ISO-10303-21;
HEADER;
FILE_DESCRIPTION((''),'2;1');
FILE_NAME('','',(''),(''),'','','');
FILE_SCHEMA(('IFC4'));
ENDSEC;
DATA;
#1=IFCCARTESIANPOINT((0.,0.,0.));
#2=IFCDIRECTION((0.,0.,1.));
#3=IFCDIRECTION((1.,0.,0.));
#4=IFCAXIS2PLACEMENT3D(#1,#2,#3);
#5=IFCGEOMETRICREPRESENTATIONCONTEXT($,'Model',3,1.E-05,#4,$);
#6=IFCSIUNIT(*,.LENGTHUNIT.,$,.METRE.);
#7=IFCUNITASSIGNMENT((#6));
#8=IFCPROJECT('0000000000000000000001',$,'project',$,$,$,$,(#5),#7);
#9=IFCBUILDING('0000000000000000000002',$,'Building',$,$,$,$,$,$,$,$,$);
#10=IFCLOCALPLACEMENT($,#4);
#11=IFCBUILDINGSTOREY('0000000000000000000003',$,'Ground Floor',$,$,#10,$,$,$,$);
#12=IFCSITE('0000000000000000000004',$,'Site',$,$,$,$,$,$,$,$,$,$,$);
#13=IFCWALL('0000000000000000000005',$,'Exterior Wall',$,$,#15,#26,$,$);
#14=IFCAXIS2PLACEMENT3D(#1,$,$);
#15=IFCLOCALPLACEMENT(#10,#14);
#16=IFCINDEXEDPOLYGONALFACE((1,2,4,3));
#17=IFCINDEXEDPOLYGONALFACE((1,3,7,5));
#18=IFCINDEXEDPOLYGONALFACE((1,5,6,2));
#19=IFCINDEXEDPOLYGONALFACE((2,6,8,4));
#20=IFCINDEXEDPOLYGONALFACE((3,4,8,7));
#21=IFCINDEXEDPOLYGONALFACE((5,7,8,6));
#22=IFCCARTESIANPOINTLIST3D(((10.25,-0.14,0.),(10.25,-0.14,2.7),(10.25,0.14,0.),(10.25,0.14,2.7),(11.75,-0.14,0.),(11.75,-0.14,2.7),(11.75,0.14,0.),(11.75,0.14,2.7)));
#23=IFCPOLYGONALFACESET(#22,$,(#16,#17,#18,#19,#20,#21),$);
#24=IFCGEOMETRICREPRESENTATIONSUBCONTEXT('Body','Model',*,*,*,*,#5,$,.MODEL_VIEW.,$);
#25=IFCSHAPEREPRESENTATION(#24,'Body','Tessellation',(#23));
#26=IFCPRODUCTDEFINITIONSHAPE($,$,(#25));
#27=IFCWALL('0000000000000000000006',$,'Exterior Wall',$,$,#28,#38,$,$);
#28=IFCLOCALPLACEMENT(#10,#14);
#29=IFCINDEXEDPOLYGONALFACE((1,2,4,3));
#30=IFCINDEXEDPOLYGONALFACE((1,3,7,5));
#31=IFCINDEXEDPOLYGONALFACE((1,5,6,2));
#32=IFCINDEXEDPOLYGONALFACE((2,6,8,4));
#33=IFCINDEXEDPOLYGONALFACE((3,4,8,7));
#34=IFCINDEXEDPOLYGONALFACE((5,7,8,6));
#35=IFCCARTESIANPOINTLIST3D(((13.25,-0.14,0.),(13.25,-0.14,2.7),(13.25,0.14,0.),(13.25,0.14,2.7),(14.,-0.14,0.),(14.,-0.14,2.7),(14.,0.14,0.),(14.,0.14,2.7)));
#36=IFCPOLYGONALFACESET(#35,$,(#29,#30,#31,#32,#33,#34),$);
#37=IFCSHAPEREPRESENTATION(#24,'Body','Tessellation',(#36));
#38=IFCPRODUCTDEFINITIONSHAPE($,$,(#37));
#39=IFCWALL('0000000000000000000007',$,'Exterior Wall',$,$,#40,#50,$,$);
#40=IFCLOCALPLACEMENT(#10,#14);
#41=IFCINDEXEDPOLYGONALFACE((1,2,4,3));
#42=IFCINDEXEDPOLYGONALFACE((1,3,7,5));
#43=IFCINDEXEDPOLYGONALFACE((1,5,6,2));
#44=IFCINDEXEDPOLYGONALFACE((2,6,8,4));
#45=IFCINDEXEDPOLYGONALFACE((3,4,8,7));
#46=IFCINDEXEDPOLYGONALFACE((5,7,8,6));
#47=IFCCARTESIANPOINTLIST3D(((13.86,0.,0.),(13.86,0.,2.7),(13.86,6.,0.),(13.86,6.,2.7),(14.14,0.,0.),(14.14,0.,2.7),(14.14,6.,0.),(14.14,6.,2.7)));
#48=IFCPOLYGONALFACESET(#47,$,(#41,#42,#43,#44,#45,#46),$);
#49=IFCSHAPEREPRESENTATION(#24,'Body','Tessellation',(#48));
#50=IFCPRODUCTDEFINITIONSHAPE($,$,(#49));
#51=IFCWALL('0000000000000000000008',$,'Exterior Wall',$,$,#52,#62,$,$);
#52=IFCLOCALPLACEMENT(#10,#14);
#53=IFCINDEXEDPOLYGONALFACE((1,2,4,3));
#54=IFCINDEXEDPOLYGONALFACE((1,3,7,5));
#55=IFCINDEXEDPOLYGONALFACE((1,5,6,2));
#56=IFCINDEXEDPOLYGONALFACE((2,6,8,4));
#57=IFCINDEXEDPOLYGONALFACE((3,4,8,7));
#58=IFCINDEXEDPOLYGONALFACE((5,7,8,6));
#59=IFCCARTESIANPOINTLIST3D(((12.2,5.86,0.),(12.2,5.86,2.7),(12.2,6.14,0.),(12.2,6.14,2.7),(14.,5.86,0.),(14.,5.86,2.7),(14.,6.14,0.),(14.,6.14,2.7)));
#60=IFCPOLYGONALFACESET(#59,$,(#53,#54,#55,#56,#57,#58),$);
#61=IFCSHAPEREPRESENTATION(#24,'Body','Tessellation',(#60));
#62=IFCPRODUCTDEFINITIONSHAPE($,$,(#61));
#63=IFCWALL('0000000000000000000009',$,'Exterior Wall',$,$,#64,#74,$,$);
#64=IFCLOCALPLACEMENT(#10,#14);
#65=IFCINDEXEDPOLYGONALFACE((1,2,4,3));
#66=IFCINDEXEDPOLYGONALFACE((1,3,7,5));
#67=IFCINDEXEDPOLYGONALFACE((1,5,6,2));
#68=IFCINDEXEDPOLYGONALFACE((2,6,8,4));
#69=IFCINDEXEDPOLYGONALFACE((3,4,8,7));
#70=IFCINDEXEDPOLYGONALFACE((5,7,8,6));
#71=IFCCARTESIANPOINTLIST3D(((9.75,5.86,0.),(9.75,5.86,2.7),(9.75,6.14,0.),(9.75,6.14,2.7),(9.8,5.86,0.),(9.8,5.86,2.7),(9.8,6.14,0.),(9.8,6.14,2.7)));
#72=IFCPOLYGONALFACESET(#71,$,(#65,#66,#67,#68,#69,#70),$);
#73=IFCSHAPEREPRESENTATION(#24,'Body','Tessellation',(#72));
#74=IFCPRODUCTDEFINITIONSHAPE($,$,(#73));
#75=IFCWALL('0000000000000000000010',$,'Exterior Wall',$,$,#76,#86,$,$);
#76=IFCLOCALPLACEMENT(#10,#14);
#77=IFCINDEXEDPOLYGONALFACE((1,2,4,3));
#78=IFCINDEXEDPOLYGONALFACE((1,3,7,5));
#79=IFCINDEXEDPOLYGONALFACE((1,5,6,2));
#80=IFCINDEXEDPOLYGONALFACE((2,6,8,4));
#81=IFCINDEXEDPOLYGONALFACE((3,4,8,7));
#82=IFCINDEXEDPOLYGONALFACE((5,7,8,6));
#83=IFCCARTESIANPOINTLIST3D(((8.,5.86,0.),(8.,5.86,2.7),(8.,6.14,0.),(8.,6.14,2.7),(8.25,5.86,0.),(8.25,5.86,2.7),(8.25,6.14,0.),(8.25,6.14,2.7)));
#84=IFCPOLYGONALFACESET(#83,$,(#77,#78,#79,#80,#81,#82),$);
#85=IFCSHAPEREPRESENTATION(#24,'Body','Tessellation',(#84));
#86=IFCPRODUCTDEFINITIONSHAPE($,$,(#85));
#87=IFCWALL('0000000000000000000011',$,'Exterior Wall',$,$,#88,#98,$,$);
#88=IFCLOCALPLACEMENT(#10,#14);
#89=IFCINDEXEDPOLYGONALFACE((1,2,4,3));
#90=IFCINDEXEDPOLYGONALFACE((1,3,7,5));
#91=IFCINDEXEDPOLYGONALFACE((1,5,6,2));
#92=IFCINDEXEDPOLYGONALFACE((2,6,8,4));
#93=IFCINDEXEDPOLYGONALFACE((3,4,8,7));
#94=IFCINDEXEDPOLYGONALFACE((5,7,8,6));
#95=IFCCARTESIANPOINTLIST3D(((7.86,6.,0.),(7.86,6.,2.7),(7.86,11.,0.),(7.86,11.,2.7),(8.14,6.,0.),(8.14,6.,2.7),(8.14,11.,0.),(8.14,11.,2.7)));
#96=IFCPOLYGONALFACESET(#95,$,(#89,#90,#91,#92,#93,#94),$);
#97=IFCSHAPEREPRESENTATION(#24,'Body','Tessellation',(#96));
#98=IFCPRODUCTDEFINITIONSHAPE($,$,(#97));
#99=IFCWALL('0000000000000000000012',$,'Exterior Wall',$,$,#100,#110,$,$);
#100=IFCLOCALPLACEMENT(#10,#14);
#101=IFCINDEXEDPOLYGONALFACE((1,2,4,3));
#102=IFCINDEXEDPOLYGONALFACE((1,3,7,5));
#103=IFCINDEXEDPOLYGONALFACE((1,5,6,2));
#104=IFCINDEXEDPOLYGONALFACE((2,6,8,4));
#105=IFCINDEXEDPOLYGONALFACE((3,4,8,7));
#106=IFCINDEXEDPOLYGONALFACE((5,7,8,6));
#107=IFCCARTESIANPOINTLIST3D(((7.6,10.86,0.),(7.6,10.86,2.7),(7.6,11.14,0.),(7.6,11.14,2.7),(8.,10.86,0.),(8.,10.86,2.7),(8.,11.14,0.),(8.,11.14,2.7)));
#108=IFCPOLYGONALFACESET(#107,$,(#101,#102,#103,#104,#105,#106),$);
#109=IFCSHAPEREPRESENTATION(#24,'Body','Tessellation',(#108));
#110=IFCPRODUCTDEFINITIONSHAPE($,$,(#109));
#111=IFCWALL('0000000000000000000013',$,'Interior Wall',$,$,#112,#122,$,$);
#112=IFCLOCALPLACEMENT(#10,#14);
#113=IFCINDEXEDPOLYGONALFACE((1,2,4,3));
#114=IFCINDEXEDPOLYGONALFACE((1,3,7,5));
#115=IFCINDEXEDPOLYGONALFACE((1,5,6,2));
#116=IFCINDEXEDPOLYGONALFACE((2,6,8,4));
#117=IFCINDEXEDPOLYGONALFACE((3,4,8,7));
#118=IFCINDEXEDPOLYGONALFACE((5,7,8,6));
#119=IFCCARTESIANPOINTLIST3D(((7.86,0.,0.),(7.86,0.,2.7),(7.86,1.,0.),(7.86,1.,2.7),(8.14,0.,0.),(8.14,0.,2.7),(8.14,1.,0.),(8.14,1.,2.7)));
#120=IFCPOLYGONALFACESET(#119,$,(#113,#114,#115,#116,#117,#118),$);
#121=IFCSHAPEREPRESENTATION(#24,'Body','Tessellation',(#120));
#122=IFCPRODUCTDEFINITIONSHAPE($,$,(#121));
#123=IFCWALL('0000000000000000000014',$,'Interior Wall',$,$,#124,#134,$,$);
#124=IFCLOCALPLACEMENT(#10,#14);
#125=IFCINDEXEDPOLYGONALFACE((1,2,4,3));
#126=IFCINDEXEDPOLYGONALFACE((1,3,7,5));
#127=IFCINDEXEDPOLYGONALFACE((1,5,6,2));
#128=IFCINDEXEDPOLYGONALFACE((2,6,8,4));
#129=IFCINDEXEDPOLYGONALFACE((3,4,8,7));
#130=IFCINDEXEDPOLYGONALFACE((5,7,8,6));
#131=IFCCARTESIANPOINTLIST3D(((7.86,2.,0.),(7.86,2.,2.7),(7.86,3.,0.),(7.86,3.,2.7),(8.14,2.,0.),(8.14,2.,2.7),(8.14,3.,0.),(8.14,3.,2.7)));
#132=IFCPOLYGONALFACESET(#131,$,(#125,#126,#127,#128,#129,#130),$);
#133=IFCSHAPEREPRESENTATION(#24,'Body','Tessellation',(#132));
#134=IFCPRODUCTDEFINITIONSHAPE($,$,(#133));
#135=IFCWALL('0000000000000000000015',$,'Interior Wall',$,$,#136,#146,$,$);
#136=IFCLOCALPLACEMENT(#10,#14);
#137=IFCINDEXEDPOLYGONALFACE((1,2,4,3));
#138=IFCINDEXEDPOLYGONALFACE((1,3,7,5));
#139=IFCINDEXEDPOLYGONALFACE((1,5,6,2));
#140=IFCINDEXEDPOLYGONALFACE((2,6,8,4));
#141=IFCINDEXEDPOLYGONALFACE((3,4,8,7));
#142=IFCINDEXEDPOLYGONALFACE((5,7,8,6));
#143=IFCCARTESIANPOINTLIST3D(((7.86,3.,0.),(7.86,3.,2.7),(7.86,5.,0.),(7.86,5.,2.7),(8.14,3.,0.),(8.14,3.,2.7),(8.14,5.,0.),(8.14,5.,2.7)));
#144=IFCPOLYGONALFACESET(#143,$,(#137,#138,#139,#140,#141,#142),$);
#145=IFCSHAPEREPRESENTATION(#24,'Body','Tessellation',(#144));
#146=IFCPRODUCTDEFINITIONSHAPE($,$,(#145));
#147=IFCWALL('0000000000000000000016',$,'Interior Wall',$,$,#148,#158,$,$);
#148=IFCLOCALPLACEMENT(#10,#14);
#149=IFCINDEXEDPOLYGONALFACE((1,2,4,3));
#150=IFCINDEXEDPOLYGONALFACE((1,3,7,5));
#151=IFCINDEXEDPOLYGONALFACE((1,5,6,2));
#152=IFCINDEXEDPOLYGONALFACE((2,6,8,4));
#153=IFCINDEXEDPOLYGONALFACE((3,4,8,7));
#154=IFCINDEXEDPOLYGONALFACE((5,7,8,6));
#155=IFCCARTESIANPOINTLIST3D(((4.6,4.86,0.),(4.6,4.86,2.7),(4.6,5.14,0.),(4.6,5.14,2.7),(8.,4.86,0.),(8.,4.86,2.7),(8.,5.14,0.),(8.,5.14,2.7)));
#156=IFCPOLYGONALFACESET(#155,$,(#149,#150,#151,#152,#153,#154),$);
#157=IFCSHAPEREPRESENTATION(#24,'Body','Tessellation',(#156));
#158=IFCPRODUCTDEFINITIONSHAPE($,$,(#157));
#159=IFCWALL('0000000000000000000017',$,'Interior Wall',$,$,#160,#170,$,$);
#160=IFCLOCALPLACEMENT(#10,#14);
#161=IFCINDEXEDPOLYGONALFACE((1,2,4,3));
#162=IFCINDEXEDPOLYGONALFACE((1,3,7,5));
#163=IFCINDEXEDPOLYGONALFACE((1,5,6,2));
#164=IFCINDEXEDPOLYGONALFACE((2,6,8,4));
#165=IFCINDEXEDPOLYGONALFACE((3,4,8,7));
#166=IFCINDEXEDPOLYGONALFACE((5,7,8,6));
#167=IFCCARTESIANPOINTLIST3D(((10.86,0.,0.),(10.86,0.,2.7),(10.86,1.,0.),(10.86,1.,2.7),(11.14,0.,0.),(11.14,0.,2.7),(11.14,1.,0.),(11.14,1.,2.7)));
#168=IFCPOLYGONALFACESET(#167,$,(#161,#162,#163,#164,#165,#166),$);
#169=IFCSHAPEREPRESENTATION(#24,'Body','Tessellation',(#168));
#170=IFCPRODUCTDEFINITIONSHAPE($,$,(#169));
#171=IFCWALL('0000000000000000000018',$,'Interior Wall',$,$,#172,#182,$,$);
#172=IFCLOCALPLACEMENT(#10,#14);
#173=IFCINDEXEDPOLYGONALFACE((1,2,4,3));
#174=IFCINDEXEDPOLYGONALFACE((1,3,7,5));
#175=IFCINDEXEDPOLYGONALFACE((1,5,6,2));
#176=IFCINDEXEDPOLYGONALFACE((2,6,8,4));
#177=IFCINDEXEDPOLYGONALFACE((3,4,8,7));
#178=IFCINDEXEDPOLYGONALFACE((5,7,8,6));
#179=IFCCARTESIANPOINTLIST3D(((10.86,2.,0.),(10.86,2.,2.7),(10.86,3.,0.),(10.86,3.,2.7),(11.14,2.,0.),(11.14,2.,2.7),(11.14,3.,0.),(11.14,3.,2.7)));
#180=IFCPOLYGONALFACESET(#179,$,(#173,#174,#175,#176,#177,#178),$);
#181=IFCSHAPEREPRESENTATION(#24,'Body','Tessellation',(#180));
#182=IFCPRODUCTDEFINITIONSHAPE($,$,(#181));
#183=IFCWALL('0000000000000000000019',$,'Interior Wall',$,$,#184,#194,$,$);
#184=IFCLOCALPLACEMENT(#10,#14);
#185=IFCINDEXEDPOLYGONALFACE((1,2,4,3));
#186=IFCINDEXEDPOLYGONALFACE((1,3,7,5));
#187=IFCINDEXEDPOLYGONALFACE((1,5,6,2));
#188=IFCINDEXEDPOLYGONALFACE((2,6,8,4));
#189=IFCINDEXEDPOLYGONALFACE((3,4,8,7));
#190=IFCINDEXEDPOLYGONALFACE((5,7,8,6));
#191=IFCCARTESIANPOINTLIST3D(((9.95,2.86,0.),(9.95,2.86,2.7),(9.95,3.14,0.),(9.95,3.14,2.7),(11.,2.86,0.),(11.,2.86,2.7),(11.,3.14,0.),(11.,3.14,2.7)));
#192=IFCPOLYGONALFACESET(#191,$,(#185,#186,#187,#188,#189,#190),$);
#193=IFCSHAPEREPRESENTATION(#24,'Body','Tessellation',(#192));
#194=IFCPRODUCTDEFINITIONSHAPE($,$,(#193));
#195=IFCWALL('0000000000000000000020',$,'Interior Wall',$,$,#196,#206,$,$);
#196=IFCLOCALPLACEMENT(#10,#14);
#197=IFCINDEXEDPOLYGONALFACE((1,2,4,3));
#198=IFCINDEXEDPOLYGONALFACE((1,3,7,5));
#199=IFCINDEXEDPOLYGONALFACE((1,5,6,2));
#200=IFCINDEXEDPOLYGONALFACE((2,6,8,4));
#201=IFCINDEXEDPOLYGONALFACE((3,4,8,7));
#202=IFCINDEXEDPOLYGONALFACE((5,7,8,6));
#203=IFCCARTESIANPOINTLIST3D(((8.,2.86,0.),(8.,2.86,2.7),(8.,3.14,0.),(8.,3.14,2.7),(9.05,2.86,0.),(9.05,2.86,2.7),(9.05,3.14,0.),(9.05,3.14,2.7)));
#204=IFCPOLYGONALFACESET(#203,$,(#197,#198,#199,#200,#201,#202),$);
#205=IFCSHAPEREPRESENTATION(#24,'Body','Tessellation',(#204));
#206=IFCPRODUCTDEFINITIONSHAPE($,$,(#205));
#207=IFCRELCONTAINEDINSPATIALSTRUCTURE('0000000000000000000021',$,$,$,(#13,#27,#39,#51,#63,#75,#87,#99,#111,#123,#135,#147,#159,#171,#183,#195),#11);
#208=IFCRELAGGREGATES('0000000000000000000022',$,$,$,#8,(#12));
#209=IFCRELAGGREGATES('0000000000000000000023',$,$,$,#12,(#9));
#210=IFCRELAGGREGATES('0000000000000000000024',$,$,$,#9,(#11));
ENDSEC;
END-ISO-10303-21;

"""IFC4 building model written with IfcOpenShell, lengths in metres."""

from ifc_helpers import new_model, si_unit, frame, origin_with_axes, place, context, subcontext, project, spatial, indexed_curve, outline, extrude, element, save


model = new_model("IFC4")

# Units and contexts
model_context = context("Model", 3, precision=1e-05, world=origin_with_axes())
body_context = subcontext(model_context, "Body", "Model", "MODEL_VIEW")
ifc_project = project(units=[si_unit("LENGTHUNIT", "METRE")], contexts=[model_context])

# Site, building, storey
site = spatial("IfcSite", under=ifc_project, Name="Site")
building = spatial("IfcBuilding", under=site, Name="Building")
storey_placement = place(None, origin_with_axes())
storey = spatial("IfcBuildingStorey", under=building, at=storey_placement, Name="Ground Floor")

# Walls
wall_1_placement = place(storey_placement, frame((10.25, 0.0, 0.0), z_axis=(0.0, 0.0, 1.0), x_axis=(1.0, 0.0, 0.0)))
element("IfcWall", 1, at=wall_1_placement, inside=storey, Name="Exterior Wall", context=body_context, shape_type="SweptSolid", body=[
    extrude(outline(indexed_curve([(0.0, 0.0), (0.0, 0.28), (1.5, 0.28), (1.5, 0.0), (0.0, 0.0)], self_intersect=False)), frame((0.0, -0.14, 0.0), z_axis=(0.0, 0.0, 1.0), x_axis=(1.0, 0.0, 0.0)), (0.0, 0.0, 1.0), 2.7),
])
wall_2_placement = place(storey_placement, frame((13.25, 0.0, 0.0), z_axis=(0.0, 0.0, 1.0), x_axis=(1.0, 0.0, 0.0)))
element("IfcWall", 2, at=wall_2_placement, inside=storey, Name="Exterior Wall", context=body_context, shape_type="SweptSolid", body=[
    extrude(outline(indexed_curve([(0.0, 0.0), (0.0, 0.28), (0.75, 0.28), (0.75, 0.0), (0.0, 0.0)], self_intersect=False)), frame((0.0, -0.14, 0.0), z_axis=(0.0, 0.0, 1.0), x_axis=(1.0, 0.0, 0.0)), (0.0, 0.0, 1.0), 2.7),
])
wall_3_placement = place(storey_placement, frame((14.0, 0.0, 0.0), z_axis=(0.0, 0.0, 1.0), x_axis=(0.0, 1.0, 0.0)))
element("IfcWall", 3, at=wall_3_placement, inside=storey, Name="Exterior Wall", context=body_context, shape_type="SweptSolid", body=[
    extrude(outline(indexed_curve([(0.0, 0.0), (0.0, 0.28), (6.0, 0.28), (6.0, 0.0), (0.0, 0.0)], self_intersect=False)), frame((0.0, -0.14, 0.0), z_axis=(0.0, 0.0, 1.0), x_axis=(1.0, 0.0, 0.0)), (0.0, 0.0, 1.0), 2.7),
])
wall_4_placement = place(storey_placement, frame((14.0, 6.0, 0.0), z_axis=(0.0, 0.0, 1.0), x_axis=(-1.0, 0.0, 0.0)))
element("IfcWall", 4, at=wall_4_placement, inside=storey, Name="Exterior Wall", context=body_context, shape_type="SweptSolid", body=[
    extrude(outline(indexed_curve([(0.0, 0.0), (0.0, 0.28), (1.8, 0.28), (1.8, 0.0), (0.0, 0.0)], self_intersect=False)), frame((0.0, -0.14, 0.0), z_axis=(0.0, 0.0, 1.0), x_axis=(1.0, 0.0, 0.0)), (0.0, 0.0, 1.0), 2.7),
])
wall_5_placement = place(storey_placement, frame((9.8, 6.0, 0.0), z_axis=(0.0, 0.0, 1.0), x_axis=(-1.0, 0.0, 0.0)))
element("IfcWall", 5, at=wall_5_placement, inside=storey, Name="Exterior Wall", context=body_context, shape_type="SweptSolid", body=[
    extrude(outline(indexed_curve([(0.0, 0.0), (0.0, 0.28), (0.05, 0.28), (0.05, 0.0), (0.0, 0.0)], self_intersect=False)), frame((0.0, -0.14, 0.0), z_axis=(0.0, 0.0, 1.0), x_axis=(1.0, 0.0, 0.0)), (0.0, 0.0, 1.0), 2.7),
])
wall_6_placement = place(storey_placement, frame((8.25, 6.0, 0.0), z_axis=(0.0, 0.0, 1.0), x_axis=(-1.0, 0.0, 0.0)))
element("IfcWall", 6, at=wall_6_placement, inside=storey, Name="Exterior Wall", context=body_context, shape_type="SweptSolid", body=[
    extrude(outline(indexed_curve([(0.0, 0.0), (0.0, 0.28), (0.25, 0.28), (0.25, 0.0), (0.0, 0.0)], self_intersect=False)), frame((0.0, -0.14, 0.0), z_axis=(0.0, 0.0, 1.0), x_axis=(1.0, 0.0, 0.0)), (0.0, 0.0, 1.0), 2.7),
])
wall_7_placement = place(storey_placement, frame((8.0, 6.0, 0.0), z_axis=(0.0, 0.0, 1.0), x_axis=(0.0, 1.0, 0.0)))
element("IfcWall", 7, at=wall_7_placement, inside=storey, Name="Exterior Wall", context=body_context, shape_type="SweptSolid", body=[
    extrude(outline(indexed_curve([(0.0, 0.0), (0.0, 0.28), (5.0, 0.28), (5.0, 0.0), (0.0, 0.0)], self_intersect=False)), frame((0.0, -0.14, 0.0), z_axis=(0.0, 0.0, 1.0), x_axis=(1.0, 0.0, 0.0)), (0.0, 0.0, 1.0), 2.7),
])
wall_8_placement = place(storey_placement, frame((8.0, 11.0, 0.0), z_axis=(0.0, 0.0, 1.0), x_axis=(-1.0, 0.0, 0.0)))
element("IfcWall", 8, at=wall_8_placement, inside=storey, Name="Exterior Wall", context=body_context, shape_type="SweptSolid", body=[
    extrude(outline(indexed_curve([(0.0, 0.0), (0.0, 0.28), (0.4, 0.28), (0.4, 0.0), (0.0, 0.0)], self_intersect=False)), frame((0.0, -0.14, 0.0), z_axis=(0.0, 0.0, 1.0), x_axis=(1.0, 0.0, 0.0)), (0.0, 0.0, 1.0), 2.7),
])
for number, where, z_axis, x_axis, name in (
    (9, (8.0, 0.0, 0.0), (0.0, 0.0, 1.0), (0.0, 1.0, 0.0), "Interior Wall"),
    (10, (8.0, 2.0, 0.0), (0.0, 0.0, 1.0), (0.0, 1.0, 0.0), "Interior Wall"),
):
    element("IfcWall", number, at=place(storey_placement, frame(where, z_axis=z_axis, x_axis=x_axis)), inside=storey, Name=name, context=body_context, shape_type="SweptSolid", body=[
        extrude(outline(indexed_curve([(0.0, 0.0), (0.0, 0.28), (1.0, 0.28), (1.0, 0.0), (0.0, 0.0)], self_intersect=False)), frame((0.0, -0.14, 0.0), z_axis=(0.0, 0.0, 1.0), x_axis=(1.0, 0.0, 0.0)), (0.0, 0.0, 1.0), 2.7),
    ])
wall_9_placement = place(storey_placement, frame((8.0, 3.0, 0.0), z_axis=(0.0, 0.0, 1.0), x_axis=(0.0, 1.0, 0.0)))
element("IfcWall", 11, at=wall_9_placement, inside=storey, Name="Interior Wall", context=body_context, shape_type="SweptSolid", body=[
    extrude(outline(indexed_curve([(0.0, 0.0), (0.0, 0.28), (2.0, 0.28), (2.0, 0.0), (0.0, 0.0)], self_intersect=False)), frame((0.0, -0.14, 0.0), z_axis=(0.0, 0.0, 1.0), x_axis=(1.0, 0.0, 0.0)), (0.0, 0.0, 1.0), 2.7),
])
wall_10_placement = place(storey_placement, frame((8.0, 5.0, 0.0), z_axis=(0.0, 0.0, 1.0), x_axis=(-1.0, 0.0, 0.0)))
element("IfcWall", 12, at=wall_10_placement, inside=storey, Name="Interior Wall", context=body_context, shape_type="SweptSolid", body=[
    extrude(outline(indexed_curve([(0.0, 0.0), (0.0, 0.28), (3.4, 0.28), (3.4, 0.0), (0.0, 0.0)], self_intersect=False)), frame((0.0, -0.14, 0.0), z_axis=(0.0, 0.0, 1.0), x_axis=(1.0, 0.0, 0.0)), (0.0, 0.0, 1.0), 2.7),
])
for number, where, z_axis, x_axis, name in (
    (13, (11.0, 0.0, 0.0), (0.0, 0.0, 1.0), (0.0, 1.0, 0.0), "Interior Wall"),
    (14, (11.0, 2.0, 0.0), (0.0, 0.0, 1.0), (0.0, 1.0, 0.0), "Interior Wall"),
):
    element("IfcWall", number, at=place(storey_placement, frame(where, z_axis=z_axis, x_axis=x_axis)), inside=storey, Name=name, context=body_context, shape_type="SweptSolid", body=[
        extrude(outline(indexed_curve([(0.0, 0.0), (0.0, 0.28), (1.0, 0.28), (1.0, 0.0), (0.0, 0.0)], self_intersect=False)), frame((0.0, -0.14, 0.0), z_axis=(0.0, 0.0, 1.0), x_axis=(1.0, 0.0, 0.0)), (0.0, 0.0, 1.0), 2.7),
    ])
for number, where, z_axis, x_axis, name in (
    (15, (11.0, 3.0, 0.0), (0.0, 0.0, 1.0), (-1.0, 0.0, 0.0), "Interior Wall"),
    (16, (9.05, 3.0, 0.0), (0.0, 0.0, 1.0), (-1.0, 0.0, 0.0), "Interior Wall"),
):
    element("IfcWall", number, at=place(storey_placement, frame(where, z_axis=z_axis, x_axis=x_axis)), inside=storey, Name=name, context=body_context, shape_type="SweptSolid", body=[
        extrude(outline(indexed_curve([(0.0, 0.0), (0.0, 0.28), (1.05, 0.28), (1.05, 0.0), (0.0, 0.0)], self_intersect=False)), frame((0.0, -0.14, 0.0), z_axis=(0.0, 0.0, 1.0), x_axis=(1.0, 0.0, 0.0)), (0.0, 0.0, 1.0), 2.7),
    ])

save(model, "model.ifc")
